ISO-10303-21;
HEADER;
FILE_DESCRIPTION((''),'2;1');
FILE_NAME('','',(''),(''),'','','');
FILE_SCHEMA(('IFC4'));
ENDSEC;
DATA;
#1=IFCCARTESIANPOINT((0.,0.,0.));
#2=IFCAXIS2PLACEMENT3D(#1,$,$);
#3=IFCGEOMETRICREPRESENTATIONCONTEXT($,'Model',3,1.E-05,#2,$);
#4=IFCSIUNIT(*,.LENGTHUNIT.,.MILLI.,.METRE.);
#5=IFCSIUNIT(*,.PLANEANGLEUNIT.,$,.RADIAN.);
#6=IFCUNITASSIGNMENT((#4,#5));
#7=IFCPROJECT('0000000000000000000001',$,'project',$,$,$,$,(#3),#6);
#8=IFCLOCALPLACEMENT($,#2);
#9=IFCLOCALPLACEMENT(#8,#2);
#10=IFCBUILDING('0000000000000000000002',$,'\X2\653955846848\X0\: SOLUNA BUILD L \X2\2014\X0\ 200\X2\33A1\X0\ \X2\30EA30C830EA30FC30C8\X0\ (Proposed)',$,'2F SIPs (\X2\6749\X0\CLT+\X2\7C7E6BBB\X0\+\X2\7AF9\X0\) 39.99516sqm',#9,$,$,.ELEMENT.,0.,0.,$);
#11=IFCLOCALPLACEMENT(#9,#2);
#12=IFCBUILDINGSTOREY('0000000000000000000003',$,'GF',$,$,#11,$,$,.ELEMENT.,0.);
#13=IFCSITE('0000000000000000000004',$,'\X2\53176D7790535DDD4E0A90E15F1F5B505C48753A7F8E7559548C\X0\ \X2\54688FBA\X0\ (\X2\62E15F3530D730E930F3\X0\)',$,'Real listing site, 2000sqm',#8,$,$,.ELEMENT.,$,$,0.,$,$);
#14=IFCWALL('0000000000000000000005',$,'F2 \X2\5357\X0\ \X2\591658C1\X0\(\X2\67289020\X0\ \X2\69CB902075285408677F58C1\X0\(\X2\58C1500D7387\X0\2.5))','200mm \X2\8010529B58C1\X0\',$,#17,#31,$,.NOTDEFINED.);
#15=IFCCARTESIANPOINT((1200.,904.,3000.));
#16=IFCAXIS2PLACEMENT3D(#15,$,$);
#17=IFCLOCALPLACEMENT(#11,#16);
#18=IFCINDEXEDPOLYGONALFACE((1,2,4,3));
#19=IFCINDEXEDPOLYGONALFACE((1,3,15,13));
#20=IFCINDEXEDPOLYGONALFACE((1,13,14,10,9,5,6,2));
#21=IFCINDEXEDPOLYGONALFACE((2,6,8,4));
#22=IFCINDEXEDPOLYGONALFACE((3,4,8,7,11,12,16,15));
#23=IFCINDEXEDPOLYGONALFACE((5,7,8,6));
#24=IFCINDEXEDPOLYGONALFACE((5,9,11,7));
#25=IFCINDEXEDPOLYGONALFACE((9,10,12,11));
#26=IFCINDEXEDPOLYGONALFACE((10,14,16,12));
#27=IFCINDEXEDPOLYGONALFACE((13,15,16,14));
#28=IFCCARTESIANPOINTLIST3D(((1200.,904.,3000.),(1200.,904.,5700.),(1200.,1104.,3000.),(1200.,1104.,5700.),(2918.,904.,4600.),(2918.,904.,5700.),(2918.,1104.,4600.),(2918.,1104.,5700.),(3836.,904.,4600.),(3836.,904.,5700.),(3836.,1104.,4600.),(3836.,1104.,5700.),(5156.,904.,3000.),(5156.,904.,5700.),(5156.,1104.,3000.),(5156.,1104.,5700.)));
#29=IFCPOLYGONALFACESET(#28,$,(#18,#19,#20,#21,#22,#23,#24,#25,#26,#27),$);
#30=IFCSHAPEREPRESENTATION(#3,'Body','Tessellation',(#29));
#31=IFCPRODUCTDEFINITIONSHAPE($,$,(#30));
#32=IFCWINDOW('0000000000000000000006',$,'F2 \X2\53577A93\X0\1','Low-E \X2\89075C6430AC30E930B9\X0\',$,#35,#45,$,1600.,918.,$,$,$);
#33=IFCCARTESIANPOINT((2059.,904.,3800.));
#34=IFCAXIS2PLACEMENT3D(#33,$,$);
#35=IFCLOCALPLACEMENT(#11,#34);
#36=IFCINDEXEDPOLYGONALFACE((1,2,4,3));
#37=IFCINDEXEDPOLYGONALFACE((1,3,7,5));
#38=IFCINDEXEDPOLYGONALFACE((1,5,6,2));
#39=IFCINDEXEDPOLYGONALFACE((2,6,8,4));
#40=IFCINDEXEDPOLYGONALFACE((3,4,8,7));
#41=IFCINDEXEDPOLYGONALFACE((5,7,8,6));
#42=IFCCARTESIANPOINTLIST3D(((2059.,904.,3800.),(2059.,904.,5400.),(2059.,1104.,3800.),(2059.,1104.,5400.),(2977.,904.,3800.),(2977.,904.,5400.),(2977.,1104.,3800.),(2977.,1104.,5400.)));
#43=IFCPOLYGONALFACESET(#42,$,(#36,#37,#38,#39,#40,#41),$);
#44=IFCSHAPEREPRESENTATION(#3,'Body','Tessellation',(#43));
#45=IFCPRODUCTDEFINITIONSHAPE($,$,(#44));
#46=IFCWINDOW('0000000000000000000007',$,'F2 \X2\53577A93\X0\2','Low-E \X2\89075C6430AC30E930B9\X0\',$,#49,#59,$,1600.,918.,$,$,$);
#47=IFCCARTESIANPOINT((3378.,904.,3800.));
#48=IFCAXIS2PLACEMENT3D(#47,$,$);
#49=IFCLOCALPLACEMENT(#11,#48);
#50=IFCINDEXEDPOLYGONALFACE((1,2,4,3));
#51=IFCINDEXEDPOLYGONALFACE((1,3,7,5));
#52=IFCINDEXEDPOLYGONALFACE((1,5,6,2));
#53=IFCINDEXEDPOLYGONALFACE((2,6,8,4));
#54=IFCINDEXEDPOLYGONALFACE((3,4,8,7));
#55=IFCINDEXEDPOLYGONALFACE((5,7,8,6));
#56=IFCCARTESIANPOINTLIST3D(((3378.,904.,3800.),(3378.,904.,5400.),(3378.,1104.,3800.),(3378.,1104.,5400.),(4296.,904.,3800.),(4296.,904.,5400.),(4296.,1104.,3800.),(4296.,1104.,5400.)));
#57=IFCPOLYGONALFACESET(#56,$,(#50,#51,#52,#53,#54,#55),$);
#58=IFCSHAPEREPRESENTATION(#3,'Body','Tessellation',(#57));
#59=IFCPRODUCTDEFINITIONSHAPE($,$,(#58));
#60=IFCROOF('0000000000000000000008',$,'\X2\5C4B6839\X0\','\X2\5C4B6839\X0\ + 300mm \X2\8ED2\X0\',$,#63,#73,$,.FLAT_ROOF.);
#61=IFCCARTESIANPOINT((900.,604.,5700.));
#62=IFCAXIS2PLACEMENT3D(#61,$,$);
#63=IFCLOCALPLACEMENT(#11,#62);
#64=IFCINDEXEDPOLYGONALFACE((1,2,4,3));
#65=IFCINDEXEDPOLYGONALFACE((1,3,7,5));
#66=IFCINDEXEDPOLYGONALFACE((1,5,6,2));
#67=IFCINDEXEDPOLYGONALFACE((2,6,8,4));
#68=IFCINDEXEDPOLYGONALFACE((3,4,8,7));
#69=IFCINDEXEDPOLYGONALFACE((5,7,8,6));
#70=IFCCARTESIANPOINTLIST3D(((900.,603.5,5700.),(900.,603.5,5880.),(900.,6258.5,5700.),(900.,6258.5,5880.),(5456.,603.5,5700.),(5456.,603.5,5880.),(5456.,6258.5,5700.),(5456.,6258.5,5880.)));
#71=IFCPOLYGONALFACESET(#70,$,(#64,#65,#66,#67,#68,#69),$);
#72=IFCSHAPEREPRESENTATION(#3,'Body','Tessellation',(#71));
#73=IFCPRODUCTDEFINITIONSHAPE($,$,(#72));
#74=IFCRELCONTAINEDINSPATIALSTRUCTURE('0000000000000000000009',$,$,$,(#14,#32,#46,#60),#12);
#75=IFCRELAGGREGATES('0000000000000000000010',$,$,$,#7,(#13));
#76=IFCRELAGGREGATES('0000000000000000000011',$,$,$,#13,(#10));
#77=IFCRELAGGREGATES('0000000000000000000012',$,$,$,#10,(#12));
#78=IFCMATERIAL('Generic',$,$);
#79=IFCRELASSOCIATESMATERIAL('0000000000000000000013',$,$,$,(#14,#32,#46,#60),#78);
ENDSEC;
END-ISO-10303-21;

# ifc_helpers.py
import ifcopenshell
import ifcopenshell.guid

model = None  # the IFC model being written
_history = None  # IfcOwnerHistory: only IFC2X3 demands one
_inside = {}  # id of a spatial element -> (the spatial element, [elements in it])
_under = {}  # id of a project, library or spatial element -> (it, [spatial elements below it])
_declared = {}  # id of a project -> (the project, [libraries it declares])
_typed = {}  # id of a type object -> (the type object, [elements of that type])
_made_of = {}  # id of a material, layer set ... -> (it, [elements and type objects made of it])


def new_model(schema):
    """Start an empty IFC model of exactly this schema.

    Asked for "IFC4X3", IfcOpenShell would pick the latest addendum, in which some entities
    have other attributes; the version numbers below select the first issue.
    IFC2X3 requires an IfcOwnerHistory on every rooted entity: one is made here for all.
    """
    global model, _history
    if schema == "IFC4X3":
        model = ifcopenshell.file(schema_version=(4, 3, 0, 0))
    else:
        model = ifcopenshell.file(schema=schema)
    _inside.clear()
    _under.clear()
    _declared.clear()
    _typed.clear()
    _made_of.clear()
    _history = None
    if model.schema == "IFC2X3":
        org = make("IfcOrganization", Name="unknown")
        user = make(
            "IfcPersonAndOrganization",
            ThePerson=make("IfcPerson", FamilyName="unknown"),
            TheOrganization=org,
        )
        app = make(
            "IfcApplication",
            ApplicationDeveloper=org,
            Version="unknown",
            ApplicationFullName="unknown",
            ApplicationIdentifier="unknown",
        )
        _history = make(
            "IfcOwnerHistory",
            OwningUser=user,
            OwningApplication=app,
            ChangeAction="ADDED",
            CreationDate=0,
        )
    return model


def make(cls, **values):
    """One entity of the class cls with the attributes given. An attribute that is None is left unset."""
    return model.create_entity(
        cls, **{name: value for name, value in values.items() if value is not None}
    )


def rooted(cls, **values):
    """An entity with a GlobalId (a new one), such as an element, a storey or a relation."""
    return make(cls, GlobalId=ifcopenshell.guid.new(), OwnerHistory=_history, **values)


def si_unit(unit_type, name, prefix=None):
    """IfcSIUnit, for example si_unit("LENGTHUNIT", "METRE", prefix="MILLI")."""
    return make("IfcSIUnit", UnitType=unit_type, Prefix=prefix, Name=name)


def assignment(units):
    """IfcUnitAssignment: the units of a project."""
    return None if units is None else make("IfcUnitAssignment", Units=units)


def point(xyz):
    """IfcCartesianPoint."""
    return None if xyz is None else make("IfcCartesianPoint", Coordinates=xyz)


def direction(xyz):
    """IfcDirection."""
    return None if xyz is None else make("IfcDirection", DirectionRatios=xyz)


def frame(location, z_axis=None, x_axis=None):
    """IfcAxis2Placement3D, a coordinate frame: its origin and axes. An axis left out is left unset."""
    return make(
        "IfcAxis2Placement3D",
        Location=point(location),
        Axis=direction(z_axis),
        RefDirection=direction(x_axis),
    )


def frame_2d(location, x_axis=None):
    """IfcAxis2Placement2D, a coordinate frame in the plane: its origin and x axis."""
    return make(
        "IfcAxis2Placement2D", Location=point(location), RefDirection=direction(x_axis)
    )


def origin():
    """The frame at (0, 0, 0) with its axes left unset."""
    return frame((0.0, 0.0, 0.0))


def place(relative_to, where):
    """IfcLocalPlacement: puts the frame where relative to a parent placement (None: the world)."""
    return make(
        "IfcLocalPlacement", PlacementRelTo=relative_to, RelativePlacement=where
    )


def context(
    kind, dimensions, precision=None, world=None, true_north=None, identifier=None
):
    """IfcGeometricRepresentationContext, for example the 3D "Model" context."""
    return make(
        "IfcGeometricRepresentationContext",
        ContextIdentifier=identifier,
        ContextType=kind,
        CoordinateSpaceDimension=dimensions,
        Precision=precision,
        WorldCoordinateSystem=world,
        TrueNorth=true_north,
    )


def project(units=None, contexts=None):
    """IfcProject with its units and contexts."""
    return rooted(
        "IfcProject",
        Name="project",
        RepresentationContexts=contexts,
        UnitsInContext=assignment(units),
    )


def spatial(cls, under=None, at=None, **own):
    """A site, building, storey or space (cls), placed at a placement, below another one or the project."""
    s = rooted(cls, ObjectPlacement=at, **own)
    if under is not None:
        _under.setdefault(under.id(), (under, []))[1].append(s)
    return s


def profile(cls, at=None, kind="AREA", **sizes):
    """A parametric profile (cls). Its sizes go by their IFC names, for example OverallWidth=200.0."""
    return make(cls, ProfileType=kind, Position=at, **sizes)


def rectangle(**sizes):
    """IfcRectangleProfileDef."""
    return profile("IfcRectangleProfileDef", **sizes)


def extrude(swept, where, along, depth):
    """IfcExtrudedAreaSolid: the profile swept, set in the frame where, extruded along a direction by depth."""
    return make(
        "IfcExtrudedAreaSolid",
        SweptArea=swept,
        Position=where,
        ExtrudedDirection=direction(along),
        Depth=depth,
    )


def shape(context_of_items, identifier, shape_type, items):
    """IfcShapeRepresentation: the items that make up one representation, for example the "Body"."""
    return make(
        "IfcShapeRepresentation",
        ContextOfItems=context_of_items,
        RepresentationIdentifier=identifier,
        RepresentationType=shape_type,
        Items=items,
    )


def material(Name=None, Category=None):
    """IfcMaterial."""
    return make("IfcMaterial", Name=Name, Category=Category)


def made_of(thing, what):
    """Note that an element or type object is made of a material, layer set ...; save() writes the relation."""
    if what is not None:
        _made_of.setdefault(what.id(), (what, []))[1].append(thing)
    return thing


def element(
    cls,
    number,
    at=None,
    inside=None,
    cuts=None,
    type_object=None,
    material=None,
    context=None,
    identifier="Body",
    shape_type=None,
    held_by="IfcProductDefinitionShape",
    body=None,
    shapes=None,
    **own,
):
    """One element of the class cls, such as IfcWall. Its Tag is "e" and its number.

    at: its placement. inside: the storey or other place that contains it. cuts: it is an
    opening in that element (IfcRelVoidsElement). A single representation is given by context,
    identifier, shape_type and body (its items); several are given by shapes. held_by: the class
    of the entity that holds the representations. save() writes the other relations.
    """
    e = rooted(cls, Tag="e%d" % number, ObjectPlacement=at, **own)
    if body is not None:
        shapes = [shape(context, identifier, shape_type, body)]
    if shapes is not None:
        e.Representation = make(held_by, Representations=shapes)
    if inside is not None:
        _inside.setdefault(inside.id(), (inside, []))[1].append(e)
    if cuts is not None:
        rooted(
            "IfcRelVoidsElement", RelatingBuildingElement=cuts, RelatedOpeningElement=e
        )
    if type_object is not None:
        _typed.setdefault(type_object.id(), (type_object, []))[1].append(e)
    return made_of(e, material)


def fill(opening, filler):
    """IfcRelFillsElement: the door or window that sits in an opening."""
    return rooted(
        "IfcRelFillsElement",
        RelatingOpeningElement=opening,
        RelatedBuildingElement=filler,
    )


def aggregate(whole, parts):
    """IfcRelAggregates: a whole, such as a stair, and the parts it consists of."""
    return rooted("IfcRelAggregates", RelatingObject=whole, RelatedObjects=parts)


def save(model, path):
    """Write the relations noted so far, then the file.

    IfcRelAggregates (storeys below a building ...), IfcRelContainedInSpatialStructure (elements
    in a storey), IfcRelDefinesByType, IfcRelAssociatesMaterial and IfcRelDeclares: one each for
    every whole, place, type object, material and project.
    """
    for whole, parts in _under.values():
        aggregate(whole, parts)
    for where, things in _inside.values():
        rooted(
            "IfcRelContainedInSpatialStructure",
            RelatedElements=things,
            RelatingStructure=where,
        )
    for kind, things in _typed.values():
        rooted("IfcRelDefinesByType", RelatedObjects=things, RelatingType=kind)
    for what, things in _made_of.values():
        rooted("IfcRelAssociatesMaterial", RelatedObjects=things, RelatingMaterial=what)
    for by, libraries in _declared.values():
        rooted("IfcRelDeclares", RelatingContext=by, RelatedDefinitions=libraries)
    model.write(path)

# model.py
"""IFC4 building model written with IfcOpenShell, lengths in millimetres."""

from ifc_helpers import new_model, si_unit, frame, frame_2d, origin, place, context, project, spatial, rectangle, extrude, material, element, fill, save


model = new_model("IFC4")

# Units and contexts
model_context = context("Model", 3, precision=1e-05, world=origin())
ifc_project = project(units=[si_unit("LENGTHUNIT", "METRE", prefix="MILLI"), si_unit("PLANEANGLEUNIT", "RADIAN")], contexts=[model_context])

# Site, building, storey
site_placement = place(None, origin())
site = spatial("IfcSite", under=ifc_project, at=site_placement, Name="北海道川上郡弟子屈町美留和 周辺 (拡張プラン)", ObjectType="Real listing site, 2000sqm", CompositionType="ELEMENT", RefElevation=0.0)
building_placement = place(site_placement, origin())
building = spatial("IfcBuilding", under=site, at=building_placement, Name="改善案: SOLUNA BUILD L — 200㎡ リトリート (Proposed)", ObjectType="2F SIPs (杉CLT+籾殻+竹) 39.99516sqm", CompositionType="ELEMENT", ElevationOfRefHeight=0.0, ElevationOfTerrain=0.0)
storey_placement = place(building_placement, origin())
storey = spatial("IfcBuildingStorey", under=building, at=storey_placement, Name="GF", CompositionType="ELEMENT", Elevation=0.0)

# Shared definitions
ifc_material_1 = material(Name="Generic")

# Wall, openings, windows
wall_1_placement = place(storey_placement, frame((1200.0, 904.0, 3000.0)))
wall_1 = element("IfcWall", 1, at=wall_1_placement, inside=storey, material=ifc_material_1, Name="F2 南 外壁(木造 構造用合板壁(壁倍率2.5))", Description="200mm 耐力壁", PredefinedType="NOTDEFINED", context=model_context, shape_type="SweptSolid", body=[
    extrude(rectangle(XDim=3956.0, YDim=200.0, at=frame_2d((1978.0, 100.0))), frame((1200.0, 904.0, 3000.0)), (0.0, 0.0, 1.0), 2700.0),
])
opening_1_placement = place(storey_placement, frame((2059.0, 904.0, 3800.0)))
opening_1 = element("IfcOpeningElement", 2, at=opening_1_placement, cuts=wall_1, PredefinedType="NOTDEFINED", context=model_context, shape_type="SweptSolid", body=[
    extrude(rectangle(XDim=918.0, YDim=200.0, at=frame_2d((459.0, 100.0))), frame((2059.0, 904.0, 3800.0)), (0.0, 0.0, 1.0), 1600.0),
])
opening_2_placement = place(storey_placement, frame((3378.0, 904.0, 3800.0)))
opening_2 = element("IfcOpeningElement", 3, at=opening_2_placement, cuts=wall_1, PredefinedType="NOTDEFINED", context=model_context, shape_type="SweptSolid", body=[
    extrude(rectangle(XDim=918.0, YDim=200.0, at=frame_2d((459.0, 100.0))), frame((3378.0, 904.0, 3800.0)), (0.0, 0.0, 1.0), 1600.0),
])
window_1_placement = place(storey_placement, frame((2059.0, 904.0, 3800.0)))
window_1 = element("IfcWindow", 4, at=window_1_placement, inside=storey, material=ifc_material_1, Name="F2 南窓1", Description="Low-E 複層ガラス", OverallHeight=1600.0, OverallWidth=918.0, context=model_context, shape_type="SweptSolid", body=[
    extrude(rectangle(XDim=918.0, YDim=200.0, at=frame_2d((459.0, 100.0))), frame((2059.0, 904.0, 3800.0)), (0.0, 0.0, 1.0), 1600.0),
])
fill(opening_1, window_1)
window_2_placement = place(storey_placement, frame((3378.0, 904.0, 3800.0)))
window_2 = element("IfcWindow", 5, at=window_2_placement, inside=storey, material=ifc_material_1, Name="F2 南窓2", Description="Low-E 複層ガラス", OverallHeight=1600.0, OverallWidth=918.0, context=model_context, shape_type="SweptSolid", body=[
    extrude(rectangle(XDim=918.0, YDim=200.0, at=frame_2d((459.0, 100.0))), frame((3378.0, 904.0, 3800.0)), (0.0, 0.0, 1.0), 1600.0),
])
fill(opening_2, window_2)

# Roof
roof_placement = place(storey_placement, frame((900.0, 604.0, 5700.0)))
element("IfcRoof", 6, at=roof_placement, inside=storey, material=ifc_material_1, Name="屋根", Description="屋根 + 300mm 軒", PredefinedType="FLAT_ROOF", context=model_context, shape_type="SweptSolid", body=[
    extrude(rectangle(XDim=4556.0, YDim=5655.0, at=frame_2d((2278.0, 2827.0))), frame((900.0, 604.0, 5700.0)), (0.0, 0.0, 1.0), 180.0),
])

save(model, "model.ifc")
